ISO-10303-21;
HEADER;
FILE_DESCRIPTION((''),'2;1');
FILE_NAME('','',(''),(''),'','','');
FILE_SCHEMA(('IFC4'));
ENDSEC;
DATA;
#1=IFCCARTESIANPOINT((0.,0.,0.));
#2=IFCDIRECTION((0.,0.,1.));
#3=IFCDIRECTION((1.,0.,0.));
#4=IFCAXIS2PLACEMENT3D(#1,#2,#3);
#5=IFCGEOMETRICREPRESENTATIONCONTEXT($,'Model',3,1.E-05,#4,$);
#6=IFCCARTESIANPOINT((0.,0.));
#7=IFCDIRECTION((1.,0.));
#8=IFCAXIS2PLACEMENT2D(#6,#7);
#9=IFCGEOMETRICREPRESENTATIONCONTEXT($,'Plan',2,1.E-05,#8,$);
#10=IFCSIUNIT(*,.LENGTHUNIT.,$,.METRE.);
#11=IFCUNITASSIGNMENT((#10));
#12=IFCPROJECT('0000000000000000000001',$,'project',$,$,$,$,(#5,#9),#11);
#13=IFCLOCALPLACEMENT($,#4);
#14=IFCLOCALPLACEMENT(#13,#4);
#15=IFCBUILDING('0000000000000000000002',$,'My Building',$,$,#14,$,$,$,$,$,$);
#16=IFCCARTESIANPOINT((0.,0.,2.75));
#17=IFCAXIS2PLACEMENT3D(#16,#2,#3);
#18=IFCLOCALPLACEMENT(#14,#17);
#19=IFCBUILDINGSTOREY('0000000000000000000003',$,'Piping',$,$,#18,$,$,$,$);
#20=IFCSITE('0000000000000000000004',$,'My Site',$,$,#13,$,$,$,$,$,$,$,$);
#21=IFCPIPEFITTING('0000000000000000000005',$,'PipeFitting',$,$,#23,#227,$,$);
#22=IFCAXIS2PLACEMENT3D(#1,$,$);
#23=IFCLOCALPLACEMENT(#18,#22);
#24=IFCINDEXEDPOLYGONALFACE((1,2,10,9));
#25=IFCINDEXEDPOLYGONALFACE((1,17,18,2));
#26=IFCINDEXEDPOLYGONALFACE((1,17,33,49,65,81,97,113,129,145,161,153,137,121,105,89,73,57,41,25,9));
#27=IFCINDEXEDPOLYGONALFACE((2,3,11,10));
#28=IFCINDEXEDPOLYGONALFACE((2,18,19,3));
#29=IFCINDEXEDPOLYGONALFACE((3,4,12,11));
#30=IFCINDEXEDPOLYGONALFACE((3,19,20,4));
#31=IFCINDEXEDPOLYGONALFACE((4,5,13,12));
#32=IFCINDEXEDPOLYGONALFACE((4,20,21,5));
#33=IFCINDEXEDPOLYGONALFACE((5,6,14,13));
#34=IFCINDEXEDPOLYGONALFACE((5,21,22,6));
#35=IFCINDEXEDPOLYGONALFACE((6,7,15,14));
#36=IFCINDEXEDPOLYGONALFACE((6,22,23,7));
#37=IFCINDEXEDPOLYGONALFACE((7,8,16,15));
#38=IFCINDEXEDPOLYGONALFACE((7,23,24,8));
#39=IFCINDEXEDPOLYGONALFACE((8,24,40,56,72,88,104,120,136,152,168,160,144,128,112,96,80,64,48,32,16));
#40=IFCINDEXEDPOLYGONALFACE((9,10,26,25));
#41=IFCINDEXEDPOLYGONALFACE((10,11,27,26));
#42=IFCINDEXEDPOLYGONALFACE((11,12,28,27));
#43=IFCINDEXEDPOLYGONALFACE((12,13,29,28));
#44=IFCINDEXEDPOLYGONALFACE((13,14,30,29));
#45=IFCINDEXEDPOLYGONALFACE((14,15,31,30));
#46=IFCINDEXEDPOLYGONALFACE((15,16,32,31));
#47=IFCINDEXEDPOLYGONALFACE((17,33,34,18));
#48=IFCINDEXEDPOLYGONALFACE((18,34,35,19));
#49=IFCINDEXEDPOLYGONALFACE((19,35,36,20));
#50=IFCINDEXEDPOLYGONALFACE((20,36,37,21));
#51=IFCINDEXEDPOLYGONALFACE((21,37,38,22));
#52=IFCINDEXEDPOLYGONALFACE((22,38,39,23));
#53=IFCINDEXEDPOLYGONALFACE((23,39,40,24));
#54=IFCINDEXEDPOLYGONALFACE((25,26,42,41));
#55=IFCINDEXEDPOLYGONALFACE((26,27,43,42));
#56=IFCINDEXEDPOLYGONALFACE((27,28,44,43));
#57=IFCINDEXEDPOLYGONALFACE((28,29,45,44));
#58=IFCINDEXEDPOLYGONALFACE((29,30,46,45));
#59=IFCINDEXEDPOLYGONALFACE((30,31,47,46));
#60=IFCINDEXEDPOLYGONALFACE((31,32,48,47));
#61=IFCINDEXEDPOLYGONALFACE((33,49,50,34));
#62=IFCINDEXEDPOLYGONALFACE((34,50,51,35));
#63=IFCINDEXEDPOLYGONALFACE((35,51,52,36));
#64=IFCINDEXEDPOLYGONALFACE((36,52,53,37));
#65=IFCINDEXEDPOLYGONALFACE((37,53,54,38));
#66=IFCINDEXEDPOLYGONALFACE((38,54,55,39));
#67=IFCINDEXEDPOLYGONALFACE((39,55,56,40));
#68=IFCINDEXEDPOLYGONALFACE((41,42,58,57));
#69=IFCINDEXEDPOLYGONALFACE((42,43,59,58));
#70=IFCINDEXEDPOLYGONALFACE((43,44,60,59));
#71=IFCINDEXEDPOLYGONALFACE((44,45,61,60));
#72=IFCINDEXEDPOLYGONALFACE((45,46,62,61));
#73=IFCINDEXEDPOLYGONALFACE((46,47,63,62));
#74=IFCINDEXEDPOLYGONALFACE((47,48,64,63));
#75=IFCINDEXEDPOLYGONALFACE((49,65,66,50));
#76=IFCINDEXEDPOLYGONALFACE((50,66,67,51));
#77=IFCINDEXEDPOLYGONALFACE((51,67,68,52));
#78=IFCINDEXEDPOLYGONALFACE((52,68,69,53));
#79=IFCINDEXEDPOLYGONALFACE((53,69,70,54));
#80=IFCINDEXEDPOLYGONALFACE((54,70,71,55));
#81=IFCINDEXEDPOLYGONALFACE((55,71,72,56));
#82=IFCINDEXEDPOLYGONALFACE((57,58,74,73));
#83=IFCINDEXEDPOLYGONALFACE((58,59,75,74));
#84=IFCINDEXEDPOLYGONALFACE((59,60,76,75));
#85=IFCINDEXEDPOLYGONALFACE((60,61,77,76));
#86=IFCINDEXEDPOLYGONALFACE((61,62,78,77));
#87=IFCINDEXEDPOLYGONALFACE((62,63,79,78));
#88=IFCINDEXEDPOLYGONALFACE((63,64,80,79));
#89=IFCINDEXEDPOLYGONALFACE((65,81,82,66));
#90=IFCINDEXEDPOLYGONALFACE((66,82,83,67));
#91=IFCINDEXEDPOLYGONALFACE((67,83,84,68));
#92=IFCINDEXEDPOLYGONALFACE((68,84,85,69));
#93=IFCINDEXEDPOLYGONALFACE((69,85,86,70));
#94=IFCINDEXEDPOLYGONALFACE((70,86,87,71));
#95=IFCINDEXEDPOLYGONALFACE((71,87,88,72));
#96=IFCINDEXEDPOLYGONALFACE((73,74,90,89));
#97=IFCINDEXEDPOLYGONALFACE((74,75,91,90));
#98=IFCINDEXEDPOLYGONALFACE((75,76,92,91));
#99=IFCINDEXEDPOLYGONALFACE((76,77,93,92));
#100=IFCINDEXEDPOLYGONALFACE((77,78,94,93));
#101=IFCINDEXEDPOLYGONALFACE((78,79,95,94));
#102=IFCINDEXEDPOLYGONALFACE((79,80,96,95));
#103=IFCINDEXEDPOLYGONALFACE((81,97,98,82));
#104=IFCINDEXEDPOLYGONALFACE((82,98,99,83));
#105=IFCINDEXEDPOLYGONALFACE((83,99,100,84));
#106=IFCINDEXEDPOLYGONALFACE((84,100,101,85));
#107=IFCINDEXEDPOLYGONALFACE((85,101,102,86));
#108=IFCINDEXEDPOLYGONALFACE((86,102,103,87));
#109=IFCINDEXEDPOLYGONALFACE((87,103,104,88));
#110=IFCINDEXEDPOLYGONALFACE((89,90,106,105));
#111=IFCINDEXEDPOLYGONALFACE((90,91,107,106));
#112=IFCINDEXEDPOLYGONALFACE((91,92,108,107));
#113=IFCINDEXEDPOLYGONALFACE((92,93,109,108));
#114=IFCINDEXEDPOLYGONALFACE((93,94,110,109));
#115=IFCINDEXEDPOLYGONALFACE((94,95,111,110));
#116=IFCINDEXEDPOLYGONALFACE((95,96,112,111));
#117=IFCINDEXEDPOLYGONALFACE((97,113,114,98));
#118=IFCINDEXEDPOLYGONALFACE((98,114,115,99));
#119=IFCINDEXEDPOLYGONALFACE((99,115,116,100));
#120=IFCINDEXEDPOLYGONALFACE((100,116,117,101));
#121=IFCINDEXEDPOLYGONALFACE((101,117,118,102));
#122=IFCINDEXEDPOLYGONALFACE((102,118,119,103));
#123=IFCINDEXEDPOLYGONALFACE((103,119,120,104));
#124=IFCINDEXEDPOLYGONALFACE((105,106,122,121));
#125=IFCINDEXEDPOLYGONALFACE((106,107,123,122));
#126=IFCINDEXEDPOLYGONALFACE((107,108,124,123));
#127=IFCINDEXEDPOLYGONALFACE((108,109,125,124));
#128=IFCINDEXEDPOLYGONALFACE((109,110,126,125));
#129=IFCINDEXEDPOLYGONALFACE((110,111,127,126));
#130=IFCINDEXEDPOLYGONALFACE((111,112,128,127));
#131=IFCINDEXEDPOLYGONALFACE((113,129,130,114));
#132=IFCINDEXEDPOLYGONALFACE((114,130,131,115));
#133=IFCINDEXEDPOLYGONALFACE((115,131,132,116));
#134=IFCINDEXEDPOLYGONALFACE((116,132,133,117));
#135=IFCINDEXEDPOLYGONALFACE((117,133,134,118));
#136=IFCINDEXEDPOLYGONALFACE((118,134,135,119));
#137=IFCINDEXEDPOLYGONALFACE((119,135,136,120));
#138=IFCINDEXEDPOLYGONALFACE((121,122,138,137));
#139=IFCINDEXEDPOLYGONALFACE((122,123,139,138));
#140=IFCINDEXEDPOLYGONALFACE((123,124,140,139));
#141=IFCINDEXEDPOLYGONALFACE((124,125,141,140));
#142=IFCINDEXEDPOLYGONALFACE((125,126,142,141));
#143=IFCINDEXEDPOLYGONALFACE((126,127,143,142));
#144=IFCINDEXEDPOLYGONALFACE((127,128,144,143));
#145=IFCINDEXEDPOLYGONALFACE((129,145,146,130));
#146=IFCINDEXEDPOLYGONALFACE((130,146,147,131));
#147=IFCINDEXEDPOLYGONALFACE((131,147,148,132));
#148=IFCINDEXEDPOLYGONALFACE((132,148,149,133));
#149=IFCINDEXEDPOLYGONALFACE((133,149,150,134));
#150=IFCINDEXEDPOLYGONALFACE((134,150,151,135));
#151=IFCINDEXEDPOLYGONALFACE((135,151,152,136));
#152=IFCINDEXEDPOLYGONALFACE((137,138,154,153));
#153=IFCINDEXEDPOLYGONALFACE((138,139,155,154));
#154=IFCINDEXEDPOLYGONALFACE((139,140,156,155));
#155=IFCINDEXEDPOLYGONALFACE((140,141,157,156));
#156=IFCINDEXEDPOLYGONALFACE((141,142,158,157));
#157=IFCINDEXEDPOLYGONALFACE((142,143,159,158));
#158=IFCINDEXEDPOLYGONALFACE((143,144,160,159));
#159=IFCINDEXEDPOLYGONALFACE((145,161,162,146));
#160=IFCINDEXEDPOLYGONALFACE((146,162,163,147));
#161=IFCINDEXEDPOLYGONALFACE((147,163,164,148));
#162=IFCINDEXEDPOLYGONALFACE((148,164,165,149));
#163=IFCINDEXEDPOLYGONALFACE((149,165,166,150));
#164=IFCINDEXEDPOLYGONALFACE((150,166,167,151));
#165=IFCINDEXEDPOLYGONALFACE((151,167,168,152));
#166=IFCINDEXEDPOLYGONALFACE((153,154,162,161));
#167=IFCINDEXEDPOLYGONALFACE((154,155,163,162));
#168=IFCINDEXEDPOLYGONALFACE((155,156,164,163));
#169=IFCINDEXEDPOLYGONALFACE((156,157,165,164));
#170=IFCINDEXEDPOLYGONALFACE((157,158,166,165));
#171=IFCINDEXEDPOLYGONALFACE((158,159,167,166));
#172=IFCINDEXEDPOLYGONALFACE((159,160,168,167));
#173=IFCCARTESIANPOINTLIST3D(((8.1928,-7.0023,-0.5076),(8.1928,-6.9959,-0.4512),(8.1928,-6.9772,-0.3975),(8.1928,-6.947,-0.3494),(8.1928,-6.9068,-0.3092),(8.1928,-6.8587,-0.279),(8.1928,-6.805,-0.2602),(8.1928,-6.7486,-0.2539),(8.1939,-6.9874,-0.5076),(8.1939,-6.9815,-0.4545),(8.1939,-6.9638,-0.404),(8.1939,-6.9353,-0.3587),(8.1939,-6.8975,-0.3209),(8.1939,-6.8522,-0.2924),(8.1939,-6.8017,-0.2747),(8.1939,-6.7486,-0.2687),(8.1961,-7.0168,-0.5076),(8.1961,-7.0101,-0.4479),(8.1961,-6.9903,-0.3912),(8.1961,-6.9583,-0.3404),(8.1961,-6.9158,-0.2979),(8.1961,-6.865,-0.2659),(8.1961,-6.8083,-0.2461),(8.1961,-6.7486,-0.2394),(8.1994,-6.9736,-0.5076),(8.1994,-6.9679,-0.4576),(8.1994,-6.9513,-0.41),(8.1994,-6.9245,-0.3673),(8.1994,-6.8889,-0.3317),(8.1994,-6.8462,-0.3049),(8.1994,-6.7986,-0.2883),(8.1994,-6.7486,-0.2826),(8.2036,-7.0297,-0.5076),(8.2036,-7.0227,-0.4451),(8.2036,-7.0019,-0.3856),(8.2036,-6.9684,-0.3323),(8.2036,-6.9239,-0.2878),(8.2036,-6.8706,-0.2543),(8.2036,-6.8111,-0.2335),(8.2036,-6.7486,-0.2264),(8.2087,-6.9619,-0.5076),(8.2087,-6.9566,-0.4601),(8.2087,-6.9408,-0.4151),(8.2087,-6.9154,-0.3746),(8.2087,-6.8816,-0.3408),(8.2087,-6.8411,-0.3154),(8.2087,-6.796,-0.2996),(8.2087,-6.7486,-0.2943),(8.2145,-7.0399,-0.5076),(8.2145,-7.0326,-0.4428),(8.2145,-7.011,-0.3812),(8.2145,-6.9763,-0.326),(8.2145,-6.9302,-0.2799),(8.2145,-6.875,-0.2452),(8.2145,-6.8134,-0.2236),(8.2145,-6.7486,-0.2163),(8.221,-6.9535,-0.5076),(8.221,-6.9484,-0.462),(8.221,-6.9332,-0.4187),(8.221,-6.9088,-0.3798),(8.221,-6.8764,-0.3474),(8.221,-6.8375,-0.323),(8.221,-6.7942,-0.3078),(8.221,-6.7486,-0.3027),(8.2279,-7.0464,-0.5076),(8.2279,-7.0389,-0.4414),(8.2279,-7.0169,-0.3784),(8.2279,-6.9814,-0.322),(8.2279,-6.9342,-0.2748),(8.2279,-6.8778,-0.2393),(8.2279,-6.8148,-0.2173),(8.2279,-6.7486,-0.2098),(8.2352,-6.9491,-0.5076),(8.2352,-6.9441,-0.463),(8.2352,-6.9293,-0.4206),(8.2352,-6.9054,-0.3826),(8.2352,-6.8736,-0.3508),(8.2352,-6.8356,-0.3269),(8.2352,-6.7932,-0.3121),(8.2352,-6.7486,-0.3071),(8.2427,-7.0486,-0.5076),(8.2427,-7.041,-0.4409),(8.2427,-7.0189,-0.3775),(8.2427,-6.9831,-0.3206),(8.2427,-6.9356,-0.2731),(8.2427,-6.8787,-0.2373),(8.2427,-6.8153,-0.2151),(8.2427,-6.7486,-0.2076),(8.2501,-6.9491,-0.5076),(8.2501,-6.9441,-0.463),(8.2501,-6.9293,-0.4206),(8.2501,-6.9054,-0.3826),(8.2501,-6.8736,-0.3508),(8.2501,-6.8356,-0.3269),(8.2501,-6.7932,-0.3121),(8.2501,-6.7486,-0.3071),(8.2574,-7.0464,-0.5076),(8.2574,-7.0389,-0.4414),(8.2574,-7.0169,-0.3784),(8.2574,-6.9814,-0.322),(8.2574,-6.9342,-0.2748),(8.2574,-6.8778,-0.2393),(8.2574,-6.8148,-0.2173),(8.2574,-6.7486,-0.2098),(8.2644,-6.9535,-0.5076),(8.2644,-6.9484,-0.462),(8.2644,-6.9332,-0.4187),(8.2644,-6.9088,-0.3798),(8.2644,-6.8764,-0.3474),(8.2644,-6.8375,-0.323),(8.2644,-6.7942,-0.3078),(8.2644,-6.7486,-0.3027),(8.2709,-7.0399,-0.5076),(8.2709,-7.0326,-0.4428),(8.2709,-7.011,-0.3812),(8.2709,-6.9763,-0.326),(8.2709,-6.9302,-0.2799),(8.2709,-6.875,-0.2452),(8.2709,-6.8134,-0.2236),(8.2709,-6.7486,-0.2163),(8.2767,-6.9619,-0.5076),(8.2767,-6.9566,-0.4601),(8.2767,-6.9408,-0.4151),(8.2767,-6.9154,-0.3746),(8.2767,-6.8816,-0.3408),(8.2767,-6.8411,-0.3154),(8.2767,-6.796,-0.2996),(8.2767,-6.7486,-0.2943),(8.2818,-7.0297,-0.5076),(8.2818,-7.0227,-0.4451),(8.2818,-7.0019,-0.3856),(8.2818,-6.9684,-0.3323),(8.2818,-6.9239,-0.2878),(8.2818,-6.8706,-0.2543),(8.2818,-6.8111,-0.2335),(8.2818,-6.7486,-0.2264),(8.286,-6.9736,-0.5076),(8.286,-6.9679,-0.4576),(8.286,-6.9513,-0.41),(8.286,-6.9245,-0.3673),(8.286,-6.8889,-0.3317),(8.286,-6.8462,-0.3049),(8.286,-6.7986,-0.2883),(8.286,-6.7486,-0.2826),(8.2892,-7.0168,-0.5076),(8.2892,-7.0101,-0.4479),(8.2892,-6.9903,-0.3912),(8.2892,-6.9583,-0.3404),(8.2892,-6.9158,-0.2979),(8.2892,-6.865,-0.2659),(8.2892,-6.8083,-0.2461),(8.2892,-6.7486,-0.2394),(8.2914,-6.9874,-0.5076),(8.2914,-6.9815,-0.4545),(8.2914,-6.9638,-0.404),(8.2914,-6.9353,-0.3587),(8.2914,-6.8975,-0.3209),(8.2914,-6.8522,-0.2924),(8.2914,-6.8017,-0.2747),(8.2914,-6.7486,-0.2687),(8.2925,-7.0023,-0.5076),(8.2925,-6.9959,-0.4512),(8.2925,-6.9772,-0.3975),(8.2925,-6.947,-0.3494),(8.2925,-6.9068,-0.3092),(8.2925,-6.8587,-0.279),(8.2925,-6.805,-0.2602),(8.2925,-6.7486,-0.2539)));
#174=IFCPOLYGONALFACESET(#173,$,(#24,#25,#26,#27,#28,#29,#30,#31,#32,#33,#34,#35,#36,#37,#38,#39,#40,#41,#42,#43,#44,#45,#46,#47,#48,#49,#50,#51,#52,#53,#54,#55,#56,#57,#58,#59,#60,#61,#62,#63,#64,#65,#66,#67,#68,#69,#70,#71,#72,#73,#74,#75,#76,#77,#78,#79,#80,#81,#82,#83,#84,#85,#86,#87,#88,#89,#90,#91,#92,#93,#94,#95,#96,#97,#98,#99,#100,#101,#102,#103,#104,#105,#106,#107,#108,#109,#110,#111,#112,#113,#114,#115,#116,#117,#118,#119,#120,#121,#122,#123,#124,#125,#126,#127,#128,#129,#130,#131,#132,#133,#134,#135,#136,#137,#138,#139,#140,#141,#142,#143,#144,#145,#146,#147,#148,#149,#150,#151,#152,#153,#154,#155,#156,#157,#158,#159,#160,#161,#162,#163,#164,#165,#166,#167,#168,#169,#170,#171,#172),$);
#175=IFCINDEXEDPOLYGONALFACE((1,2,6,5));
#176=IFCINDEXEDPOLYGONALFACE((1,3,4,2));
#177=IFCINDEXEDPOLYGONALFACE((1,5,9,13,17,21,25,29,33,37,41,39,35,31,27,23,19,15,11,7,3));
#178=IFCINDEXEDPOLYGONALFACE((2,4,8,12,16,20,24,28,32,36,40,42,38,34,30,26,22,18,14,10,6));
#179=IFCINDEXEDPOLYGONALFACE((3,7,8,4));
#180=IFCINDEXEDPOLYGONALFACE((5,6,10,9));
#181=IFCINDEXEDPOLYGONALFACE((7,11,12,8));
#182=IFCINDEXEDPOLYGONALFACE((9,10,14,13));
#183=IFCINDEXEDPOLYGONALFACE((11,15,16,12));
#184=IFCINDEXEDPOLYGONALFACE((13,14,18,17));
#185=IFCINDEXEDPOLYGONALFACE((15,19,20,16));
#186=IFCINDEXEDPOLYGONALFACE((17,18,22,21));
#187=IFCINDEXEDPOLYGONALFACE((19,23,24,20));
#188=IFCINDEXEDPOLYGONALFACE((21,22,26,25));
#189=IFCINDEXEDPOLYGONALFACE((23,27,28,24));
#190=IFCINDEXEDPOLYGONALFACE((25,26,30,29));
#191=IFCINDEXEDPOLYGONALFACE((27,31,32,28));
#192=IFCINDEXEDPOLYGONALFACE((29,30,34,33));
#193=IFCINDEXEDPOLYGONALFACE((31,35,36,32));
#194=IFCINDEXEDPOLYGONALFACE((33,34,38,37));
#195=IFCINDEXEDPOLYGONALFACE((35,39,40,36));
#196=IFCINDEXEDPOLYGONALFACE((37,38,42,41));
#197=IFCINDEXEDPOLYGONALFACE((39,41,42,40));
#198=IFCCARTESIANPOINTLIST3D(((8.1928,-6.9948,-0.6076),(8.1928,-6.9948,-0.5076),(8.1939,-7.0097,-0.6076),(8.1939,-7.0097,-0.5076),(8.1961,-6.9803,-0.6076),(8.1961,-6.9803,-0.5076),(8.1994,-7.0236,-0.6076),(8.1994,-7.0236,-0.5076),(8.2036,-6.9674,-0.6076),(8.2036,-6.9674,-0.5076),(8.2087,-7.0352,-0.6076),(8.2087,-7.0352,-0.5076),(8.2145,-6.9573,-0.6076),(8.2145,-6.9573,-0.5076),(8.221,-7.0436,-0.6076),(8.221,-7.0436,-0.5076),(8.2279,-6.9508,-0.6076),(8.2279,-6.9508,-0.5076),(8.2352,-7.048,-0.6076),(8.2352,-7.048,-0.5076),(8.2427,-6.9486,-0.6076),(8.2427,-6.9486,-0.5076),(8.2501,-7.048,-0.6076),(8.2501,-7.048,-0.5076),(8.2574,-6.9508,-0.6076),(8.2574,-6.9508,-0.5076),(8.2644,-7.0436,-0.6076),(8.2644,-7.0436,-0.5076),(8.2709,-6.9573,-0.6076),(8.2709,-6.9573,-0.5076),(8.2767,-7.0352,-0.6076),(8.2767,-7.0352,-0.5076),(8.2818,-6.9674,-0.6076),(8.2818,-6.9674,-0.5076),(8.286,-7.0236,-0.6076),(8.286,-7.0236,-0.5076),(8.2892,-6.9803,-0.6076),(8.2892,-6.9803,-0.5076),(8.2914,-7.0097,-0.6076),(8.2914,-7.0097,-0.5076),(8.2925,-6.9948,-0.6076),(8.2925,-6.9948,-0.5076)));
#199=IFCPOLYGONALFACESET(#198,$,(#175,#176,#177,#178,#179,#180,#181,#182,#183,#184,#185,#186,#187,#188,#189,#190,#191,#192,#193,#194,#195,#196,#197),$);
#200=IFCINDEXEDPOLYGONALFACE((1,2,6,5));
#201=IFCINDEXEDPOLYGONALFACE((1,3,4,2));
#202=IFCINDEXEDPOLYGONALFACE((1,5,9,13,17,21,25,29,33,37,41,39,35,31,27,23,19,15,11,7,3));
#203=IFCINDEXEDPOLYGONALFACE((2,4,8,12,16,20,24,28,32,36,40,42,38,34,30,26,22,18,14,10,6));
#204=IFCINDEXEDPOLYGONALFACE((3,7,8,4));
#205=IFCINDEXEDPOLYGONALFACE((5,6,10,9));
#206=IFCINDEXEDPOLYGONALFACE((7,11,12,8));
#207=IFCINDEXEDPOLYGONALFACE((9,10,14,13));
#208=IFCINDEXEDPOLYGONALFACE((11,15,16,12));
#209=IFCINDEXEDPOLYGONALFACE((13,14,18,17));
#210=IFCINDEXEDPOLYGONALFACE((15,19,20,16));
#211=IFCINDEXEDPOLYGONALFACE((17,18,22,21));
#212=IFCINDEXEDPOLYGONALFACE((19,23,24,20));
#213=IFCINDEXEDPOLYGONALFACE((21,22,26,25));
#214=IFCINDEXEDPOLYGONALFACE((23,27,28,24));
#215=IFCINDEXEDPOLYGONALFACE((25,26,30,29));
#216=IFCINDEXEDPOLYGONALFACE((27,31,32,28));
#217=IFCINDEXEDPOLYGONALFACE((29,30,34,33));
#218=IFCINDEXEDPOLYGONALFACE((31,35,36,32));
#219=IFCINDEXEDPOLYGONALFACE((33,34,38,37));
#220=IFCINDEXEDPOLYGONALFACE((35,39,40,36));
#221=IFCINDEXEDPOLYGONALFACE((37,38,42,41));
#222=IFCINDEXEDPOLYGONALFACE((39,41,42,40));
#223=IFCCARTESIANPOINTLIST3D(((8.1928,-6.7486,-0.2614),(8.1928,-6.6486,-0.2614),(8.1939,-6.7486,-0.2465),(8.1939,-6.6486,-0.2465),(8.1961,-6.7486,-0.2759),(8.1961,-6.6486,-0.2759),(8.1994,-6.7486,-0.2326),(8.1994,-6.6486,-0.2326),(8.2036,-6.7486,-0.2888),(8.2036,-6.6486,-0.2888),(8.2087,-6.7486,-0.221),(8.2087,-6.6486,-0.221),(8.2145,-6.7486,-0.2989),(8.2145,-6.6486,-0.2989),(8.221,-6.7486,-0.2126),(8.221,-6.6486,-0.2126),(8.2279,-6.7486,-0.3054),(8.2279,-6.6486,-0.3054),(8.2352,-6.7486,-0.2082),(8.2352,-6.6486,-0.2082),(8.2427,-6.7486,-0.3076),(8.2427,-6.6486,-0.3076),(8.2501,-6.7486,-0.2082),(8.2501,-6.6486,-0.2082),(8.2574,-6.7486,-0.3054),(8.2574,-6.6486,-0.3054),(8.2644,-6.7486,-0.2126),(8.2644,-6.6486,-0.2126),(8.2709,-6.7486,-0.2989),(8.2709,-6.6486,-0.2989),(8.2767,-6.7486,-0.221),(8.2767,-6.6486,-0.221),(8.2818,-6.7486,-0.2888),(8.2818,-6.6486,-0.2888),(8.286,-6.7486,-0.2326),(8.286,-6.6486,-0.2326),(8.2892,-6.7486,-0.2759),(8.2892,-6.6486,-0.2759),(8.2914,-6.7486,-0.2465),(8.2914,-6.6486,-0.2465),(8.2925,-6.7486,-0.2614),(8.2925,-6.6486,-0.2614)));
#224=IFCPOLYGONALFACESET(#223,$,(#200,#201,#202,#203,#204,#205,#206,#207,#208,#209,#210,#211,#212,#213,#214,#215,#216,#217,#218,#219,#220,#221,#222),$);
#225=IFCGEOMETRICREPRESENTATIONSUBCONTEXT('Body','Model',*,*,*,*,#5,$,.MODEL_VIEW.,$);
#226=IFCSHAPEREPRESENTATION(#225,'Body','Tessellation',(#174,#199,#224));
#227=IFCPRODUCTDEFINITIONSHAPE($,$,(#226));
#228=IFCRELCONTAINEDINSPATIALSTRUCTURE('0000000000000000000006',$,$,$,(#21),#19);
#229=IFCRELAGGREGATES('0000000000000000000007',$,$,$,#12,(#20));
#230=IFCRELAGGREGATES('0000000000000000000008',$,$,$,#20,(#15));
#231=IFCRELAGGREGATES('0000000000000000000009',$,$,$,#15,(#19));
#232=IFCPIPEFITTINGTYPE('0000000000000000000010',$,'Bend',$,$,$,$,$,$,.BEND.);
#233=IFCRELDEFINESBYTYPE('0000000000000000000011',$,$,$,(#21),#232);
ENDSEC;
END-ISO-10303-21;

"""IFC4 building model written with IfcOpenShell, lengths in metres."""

from ifc_helpers import new_model, entity, si_unit, frame, origin_with_axes, origin_2d_with_axis, place, context, subcontext, project, spatial, circle, extrude, source, transform, mapped, type_object, type_shapes, element, save


model = new_model("IFC4")

# Units and contexts
model_context = context("Model", 3, precision=1e-05, world=origin_with_axes())
plan_context = context("Plan", 2, precision=1e-05, world=origin_2d_with_axis())
body_context = subcontext(model_context, "Body", "Model", "MODEL_VIEW")
ifc_project = project(units=[si_unit("LENGTHUNIT", "METRE")], contexts=[model_context, plan_context])

# Site, building, storey
site_placement = place(None, origin_with_axes())
site = spatial("IfcSite", under=ifc_project, at=site_placement, Name="My Site")
building_placement = place(site_placement, origin_with_axes())
building = spatial("IfcBuilding", under=site, at=building_placement, Name="My Building")
storey_placement = place(building_placement, frame((0.0, 0.0, 2.75), z_axis=(0.0, 0.0, 1.0), x_axis=(1.0, 0.0, 0.0)))
storey = spatial("IfcBuildingStorey", under=building, at=storey_placement, Name="Piping")

# Pipe fitting
pipe_fitting_type = type_object("IfcPipeFittingType", Name="Bend", PredefinedType="BEND")
shared_shape = source(origin_with_axes(), body_context, "Body", "SolidModel", [
    entity("IfcSweptDiskSolid", entity("IfcIndexedPolyCurve", entity("IfcCartesianPointList3D", [[0.0, 0.0, -0.1], [0.0732, 0.0, -0.2768], [0.25, 0.0, -0.35]]), [entity("IfcArcIndex", [1, 2, 3])]), 0.05),
    extrude(circle(Radius=0.05), origin_with_axes(), (0.0, 0.0, -1.0), 0.1),
    extrude(circle(Radius=0.05), frame((0.25, 0.0, -0.35), z_axis=(1.0, 0.0, 0.0), x_axis=(0.0, 0.0, 1.0)), (0.0, 0.0, 1.0), 0.1),
])
type_shapes(pipe_fitting_type, [shared_shape])
for number, where, z_axis, x_axis, name in (
    (1, (8.2427, -6.9986, -0.6076), (0.0, 0.0, -1.0), (0.0, 1.0, 0.0), "PipeFitting"),
):
    element("IfcPipeFitting", number, at=place(storey_placement, frame(where, z_axis=z_axis, x_axis=x_axis)), inside=storey, type_object=pipe_fitting_type, Name=name, context=body_context, shape_type="MappedRepresentation", body=[
        mapped(shared_shape, transform((0.0, 0.0, 0.0), x_axis=(1.0, 0.0, 0.0), y_axis=(0.0, 1.0, 0.0), z_axis=(0.0, 0.0, 1.0), scale=1.0)),
    ])

save(model, "model.ifc")
